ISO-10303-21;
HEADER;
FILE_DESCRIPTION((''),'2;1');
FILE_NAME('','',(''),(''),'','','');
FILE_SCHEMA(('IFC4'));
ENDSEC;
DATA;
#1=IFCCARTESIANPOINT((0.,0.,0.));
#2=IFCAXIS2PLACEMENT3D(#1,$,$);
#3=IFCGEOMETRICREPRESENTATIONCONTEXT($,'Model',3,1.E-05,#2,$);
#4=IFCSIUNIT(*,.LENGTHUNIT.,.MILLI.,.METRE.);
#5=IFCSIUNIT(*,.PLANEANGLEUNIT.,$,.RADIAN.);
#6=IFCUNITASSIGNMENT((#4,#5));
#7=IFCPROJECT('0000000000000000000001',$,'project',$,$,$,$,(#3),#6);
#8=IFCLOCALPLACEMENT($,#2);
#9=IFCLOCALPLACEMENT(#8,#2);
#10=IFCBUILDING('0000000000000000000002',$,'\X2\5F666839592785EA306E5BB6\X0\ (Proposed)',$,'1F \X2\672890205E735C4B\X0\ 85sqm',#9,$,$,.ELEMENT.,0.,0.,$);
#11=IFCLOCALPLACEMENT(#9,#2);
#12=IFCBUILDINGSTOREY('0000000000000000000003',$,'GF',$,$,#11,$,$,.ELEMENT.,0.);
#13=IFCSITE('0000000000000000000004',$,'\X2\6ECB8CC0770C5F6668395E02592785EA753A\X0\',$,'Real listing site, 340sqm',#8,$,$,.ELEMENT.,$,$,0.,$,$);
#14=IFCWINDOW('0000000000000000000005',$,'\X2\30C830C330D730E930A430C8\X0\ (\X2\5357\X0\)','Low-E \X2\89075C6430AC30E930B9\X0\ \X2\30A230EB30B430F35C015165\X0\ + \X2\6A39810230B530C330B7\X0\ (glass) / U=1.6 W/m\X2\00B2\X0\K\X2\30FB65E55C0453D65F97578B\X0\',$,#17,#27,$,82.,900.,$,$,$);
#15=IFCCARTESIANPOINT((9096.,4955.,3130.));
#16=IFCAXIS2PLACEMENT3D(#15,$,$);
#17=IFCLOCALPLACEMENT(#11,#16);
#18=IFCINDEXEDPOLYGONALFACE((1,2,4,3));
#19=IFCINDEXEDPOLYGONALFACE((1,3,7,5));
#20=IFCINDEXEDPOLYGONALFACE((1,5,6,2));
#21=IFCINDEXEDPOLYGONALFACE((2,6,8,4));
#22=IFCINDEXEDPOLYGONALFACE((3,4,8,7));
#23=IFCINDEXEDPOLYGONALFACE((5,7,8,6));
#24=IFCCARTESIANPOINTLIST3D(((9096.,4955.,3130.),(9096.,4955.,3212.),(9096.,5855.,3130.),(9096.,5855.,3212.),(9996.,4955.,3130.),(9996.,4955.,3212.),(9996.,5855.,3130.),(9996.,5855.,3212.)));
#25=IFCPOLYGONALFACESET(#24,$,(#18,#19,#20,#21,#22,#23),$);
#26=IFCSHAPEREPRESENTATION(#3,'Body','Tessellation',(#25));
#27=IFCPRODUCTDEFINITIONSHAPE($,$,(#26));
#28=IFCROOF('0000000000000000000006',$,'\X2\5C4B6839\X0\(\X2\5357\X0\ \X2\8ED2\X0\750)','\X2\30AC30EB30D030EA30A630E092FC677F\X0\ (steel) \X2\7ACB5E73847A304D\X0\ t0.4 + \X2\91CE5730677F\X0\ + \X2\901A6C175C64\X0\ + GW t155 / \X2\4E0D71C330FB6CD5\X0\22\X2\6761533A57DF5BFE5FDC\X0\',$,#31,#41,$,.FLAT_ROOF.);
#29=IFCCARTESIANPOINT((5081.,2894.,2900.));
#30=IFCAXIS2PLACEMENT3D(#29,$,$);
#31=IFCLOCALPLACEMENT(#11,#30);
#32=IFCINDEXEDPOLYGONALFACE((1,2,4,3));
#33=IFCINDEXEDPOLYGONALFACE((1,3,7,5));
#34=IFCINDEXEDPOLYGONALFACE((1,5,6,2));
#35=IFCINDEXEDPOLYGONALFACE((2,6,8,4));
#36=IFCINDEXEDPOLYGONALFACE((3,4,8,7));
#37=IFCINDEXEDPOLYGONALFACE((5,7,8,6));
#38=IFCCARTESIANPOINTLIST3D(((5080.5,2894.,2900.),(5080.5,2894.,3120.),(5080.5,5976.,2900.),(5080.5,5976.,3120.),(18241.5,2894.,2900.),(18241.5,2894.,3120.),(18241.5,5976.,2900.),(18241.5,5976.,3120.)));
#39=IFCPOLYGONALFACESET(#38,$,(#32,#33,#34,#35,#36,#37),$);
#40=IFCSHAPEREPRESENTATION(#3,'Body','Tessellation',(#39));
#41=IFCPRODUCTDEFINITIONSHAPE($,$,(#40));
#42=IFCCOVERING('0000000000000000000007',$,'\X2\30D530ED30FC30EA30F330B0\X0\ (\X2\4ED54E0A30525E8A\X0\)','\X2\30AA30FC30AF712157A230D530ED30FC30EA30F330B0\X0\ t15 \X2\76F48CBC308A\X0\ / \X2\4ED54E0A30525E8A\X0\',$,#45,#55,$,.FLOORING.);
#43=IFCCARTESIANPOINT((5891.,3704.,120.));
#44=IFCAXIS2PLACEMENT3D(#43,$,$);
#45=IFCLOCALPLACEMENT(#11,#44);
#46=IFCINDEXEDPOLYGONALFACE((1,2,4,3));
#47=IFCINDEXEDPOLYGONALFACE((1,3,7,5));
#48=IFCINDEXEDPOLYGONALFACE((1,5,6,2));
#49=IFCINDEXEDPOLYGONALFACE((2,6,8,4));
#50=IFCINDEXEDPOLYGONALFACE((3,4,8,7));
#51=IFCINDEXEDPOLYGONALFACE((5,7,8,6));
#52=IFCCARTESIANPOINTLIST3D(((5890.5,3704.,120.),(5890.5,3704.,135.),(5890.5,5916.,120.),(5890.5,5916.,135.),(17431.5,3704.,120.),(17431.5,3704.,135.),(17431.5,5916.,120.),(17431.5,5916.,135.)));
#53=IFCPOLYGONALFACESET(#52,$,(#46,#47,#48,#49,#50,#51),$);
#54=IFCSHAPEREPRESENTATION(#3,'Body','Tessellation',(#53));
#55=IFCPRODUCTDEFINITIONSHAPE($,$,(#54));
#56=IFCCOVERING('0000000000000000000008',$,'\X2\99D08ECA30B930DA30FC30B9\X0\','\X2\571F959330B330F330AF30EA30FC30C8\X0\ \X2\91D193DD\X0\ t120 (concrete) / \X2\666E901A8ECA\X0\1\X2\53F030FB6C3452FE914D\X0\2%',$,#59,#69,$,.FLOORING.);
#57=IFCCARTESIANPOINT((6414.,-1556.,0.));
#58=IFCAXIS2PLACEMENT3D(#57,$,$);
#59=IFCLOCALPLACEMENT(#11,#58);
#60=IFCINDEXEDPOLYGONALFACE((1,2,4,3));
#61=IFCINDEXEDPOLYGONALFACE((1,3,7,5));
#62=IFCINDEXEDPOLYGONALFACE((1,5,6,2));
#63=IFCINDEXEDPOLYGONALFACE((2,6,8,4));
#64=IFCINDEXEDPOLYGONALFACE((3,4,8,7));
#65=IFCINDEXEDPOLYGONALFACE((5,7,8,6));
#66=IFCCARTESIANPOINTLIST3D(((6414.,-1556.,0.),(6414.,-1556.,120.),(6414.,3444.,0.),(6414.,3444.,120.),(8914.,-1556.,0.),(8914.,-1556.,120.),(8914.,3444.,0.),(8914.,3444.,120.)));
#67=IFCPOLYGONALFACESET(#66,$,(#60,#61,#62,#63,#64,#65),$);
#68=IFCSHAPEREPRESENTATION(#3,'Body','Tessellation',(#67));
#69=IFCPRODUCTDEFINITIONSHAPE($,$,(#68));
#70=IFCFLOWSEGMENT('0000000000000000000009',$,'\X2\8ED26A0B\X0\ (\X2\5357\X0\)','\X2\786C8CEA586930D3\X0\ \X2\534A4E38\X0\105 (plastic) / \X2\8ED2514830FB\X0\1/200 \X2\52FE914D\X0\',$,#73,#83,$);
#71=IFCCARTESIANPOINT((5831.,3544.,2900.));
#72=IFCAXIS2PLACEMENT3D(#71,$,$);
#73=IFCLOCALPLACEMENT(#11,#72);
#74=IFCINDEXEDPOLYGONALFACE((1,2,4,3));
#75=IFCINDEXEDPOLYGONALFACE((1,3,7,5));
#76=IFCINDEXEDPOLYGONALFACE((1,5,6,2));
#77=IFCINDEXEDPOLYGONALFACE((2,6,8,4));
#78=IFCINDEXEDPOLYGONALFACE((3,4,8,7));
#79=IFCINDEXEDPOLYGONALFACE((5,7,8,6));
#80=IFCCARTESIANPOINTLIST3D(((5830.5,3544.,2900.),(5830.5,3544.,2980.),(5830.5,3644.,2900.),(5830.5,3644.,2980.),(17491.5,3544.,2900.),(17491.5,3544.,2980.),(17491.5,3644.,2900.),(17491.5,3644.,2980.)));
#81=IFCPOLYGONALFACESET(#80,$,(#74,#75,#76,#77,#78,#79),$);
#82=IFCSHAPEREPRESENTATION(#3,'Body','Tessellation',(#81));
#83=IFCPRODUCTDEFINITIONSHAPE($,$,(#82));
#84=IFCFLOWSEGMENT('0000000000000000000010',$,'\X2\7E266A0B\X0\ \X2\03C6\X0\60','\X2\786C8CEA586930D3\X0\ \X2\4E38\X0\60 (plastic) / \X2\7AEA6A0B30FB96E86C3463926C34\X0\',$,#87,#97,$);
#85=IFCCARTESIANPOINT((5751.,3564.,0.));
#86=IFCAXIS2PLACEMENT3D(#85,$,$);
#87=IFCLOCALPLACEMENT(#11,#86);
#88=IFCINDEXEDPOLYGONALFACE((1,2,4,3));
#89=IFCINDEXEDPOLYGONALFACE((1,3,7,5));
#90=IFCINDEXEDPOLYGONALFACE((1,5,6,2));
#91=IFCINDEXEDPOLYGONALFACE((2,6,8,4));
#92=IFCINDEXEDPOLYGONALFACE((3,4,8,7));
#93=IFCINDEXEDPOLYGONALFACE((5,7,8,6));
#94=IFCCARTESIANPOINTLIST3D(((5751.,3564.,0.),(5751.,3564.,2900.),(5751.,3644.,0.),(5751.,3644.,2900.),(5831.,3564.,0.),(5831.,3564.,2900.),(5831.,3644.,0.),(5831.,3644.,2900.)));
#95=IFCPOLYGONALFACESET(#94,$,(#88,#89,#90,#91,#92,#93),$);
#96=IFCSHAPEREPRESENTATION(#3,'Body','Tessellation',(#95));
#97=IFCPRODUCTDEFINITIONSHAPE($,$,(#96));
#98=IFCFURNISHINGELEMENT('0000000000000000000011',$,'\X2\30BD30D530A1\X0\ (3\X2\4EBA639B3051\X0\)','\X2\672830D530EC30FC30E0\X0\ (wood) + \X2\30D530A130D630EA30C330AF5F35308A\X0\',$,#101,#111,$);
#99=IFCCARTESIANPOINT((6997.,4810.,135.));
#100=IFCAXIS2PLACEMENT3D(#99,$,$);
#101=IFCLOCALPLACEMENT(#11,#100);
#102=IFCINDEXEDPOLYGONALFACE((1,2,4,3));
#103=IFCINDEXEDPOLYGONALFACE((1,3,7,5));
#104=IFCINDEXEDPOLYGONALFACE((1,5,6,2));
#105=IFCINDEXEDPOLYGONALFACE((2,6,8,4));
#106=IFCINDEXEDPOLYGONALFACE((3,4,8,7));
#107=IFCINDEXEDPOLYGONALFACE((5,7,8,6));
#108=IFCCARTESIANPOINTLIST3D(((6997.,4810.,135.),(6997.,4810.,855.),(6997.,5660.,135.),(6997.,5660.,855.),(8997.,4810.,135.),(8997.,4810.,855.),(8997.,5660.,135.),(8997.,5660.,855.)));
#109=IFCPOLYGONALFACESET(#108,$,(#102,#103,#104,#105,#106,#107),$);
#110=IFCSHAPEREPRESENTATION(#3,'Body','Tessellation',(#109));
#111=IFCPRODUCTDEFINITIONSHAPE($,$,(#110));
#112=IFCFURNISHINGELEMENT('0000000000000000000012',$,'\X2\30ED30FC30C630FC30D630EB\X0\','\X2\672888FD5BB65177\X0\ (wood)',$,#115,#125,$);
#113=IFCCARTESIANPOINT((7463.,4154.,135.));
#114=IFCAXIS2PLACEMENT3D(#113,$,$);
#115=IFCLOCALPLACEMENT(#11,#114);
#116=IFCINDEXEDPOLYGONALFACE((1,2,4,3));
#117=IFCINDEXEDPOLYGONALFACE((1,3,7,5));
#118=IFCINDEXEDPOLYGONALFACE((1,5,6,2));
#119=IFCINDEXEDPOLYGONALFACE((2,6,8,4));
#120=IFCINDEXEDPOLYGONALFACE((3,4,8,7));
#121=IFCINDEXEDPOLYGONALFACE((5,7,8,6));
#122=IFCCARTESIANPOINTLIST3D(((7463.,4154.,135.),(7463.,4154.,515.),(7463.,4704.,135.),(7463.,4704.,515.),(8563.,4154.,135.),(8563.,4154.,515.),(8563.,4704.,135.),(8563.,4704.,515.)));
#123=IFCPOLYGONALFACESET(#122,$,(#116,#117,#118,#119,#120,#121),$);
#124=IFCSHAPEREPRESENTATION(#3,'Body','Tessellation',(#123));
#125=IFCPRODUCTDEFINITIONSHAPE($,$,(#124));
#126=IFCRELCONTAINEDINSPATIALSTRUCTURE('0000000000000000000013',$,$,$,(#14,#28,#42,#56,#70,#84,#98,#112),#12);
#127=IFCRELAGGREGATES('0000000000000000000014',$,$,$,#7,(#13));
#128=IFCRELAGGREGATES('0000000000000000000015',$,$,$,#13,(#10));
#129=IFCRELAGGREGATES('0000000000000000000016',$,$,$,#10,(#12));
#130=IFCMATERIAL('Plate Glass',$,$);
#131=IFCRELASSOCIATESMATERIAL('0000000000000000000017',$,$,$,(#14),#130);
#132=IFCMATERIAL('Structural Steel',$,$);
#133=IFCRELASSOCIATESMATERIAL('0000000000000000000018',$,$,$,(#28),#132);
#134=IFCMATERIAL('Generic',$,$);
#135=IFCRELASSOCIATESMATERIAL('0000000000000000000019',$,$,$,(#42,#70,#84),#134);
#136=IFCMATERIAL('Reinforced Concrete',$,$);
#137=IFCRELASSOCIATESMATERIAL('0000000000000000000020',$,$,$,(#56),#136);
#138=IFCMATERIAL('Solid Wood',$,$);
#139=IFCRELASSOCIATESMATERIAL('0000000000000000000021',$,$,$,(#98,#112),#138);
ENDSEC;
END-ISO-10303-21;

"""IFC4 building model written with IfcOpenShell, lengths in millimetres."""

from ifc_helpers import new_model, si_unit, frame, frame_2d, origin, place, context, project, spatial, rectangle, extrude, material, element, save


model = new_model("IFC4")

# Units and contexts
model_context = context("Model", 3, precision=1e-05, world=origin())
ifc_project = project(units=[si_unit("LENGTHUNIT", "METRE", prefix="MILLI"), si_unit("PLANEANGLEUNIT", "RADIAN")], contexts=[model_context])

# Site, building, storey
site_placement = place(None, origin())
site = spatial("IfcSite", under=ifc_project, at=site_placement, Name="滋賀県彦根市大藪町", ObjectType="Real listing site, 340sqm", CompositionType="ELEMENT", RefElevation=0.0)
building_placement = place(site_placement, origin())
building = spatial("IfcBuilding", under=site, at=building_placement, Name="彦根大藪の家 (Proposed)", ObjectType="1F 木造平屋 85sqm", CompositionType="ELEMENT", ElevationOfRefHeight=0.0, ElevationOfTerrain=0.0)
storey_placement = place(building_placement, origin())
storey = spatial("IfcBuildingStorey", under=building, at=storey_placement, Name="GF", CompositionType="ELEMENT", Elevation=0.0)

# Shared definitions
ifc_material_1 = material(Name="Solid Wood")

# Shared definitions
ifc_material_2 = material(Name="Reinforced Concrete")

# Shared definitions
ifc_material_3 = material(Name="Plate Glass")

# Window
window_1_placement = place(storey_placement, frame((9096.0, 4955.0, 3130.0)))
element("IfcWindow", 1, at=window_1_placement, inside=storey, material=ifc_material_3, Name="トップライト (南)", Description="Low-E 複層ガラス アルゴン封入 + 樹脂サッシ (glass) / U=1.6 W/m²K・日射取得型", OverallHeight=82.0, OverallWidth=900.0, context=model_context, shape_type="SweptSolid", body=[
    extrude(rectangle(XDim=900.0, YDim=900.0, at=frame_2d((450.0, 450.0))), frame((9096.0, 4955.0, 3130.0)), (0.0, 0.0, 1.0), 82.0),
])

# Roof
ifc_material_4 = material(Name="Structural Steel")
roof_1_placement = place(storey_placement, frame((5081.0, 2894.0, 2900.0)))
element("IfcRoof", 2, at=roof_1_placement, inside=storey, material=ifc_material_4, Name="屋根(南 軒750)", Description="ガルバリウム鋼板 (steel) 立平葺き t0.4 + 野地板 + 通気層 + GW t155 / 不燃・法22条区域対応", PredefinedType="FLAT_ROOF", context=model_context, shape_type="SweptSolid", body=[
    extrude(rectangle(XDim=13161.0, YDim=3082.0, at=frame_2d((6580.0, 1541.0))), frame((5081.0, 2894.0, 2900.0)), (0.0, 0.0, 1.0), 220.0),
])

# Coverings
ifc_material_5 = material(Name="Generic")
covering_1_placement = place(storey_placement, frame((5891.0, 3704.0, 120.0)))
element("IfcCovering", 3, at=covering_1_placement, inside=storey, material=ifc_material_5, Name="フローリング (仕上げ床)", Description="オーク無垢フローリング t15 直貼り / 仕上げ床", PredefinedType="FLOORING", context=model_context, shape_type="SweptSolid", body=[
    extrude(rectangle(XDim=11541.0, YDim=2212.0, at=frame_2d((5770.0, 1106.0))), frame((5891.0, 3704.0, 120.0)), (0.0, 0.0, 1.0), 15.0),
])
covering_2_placement = place(storey_placement, frame((6414.0, -1556.0, 0.0)))
element("IfcCovering", 4, at=covering_2_placement, inside=storey, material=ifc_material_2, Name="駐車スペース", Description="土間コンクリート 金鏝 t120 (concrete) / 普通車1台・水勾配2%", PredefinedType="FLOORING", context=model_context, shape_type="SweptSolid", body=[
    extrude(rectangle(XDim=2500.0, YDim=5000.0, at=frame_2d((1250.0, 2500.0))), frame((6414.0, -1556.0, 0.0)), (0.0, 0.0, 1.0), 120.0),
])

# Flow segments
flow_segment_1_placement = place(storey_placement, frame((5831.0, 3544.0, 2900.0)))
element("IfcFlowSegment", 5, at=flow_segment_1_placement, inside=storey, material=ifc_material_5, Name="軒樋 (南)", Description="硬質塩ビ 半丸105 (plastic) / 軒先・1/200 勾配", context=model_context, shape_type="SweptSolid", body=[
    extrude(rectangle(XDim=11661.0, YDim=100.0, at=frame_2d((5830.0, 50.0))), frame((5831.0, 3544.0, 2900.0)), (0.0, 0.0, 1.0), 80.0),
])
flow_segment_2_placement = place(storey_placement, frame((5751.0, 3564.0, 0.0)))
element("IfcFlowSegment", 6, at=flow_segment_2_placement, inside=storey, material=ifc_material_5, Name="縦樋 φ60", Description="硬質塩ビ 丸60 (plastic) / 竪樋・雨水排水", context=model_context, shape_type="SweptSolid", body=[
    extrude(rectangle(XDim=80.0, YDim=80.0, at=frame_2d((40.0, 40.0))), frame((5751.0, 3564.0, 0.0)), (0.0, 0.0, 1.0), 2900.0),
])

# Furnishing elements
furnishing_1_placement = place(storey_placement, frame((6997.0, 4810.0, 135.0)))
element("IfcFurnishingElement", 7, at=furnishing_1_placement, inside=storey, material=ifc_material_1, Name="ソファ (3人掛け)", Description="木フレーム (wood) + ファブリック張り", context=model_context, shape_type="SweptSolid", body=[
    extrude(rectangle(XDim=2000.0, YDim=850.0, at=frame_2d((1000.0, 425.0))), frame((6997.0, 4810.0, 135.0)), (0.0, 0.0, 1.0), 720.0),
])
furnishing_2_placement = place(storey_placement, frame((7463.0, 4154.0, 135.0)))
element("IfcFurnishingElement", 8, at=furnishing_2_placement, inside=storey, material=ifc_material_1, Name="ローテーブル", Description="木製家具 (wood)", context=model_context, shape_type="SweptSolid", body=[
    extrude(rectangle(XDim=1100.0, YDim=550.0, at=frame_2d((550.0, 275.0))), frame((7463.0, 4154.0, 135.0)), (0.0, 0.0, 1.0), 380.0),
])

save(model, "model.ifc")
